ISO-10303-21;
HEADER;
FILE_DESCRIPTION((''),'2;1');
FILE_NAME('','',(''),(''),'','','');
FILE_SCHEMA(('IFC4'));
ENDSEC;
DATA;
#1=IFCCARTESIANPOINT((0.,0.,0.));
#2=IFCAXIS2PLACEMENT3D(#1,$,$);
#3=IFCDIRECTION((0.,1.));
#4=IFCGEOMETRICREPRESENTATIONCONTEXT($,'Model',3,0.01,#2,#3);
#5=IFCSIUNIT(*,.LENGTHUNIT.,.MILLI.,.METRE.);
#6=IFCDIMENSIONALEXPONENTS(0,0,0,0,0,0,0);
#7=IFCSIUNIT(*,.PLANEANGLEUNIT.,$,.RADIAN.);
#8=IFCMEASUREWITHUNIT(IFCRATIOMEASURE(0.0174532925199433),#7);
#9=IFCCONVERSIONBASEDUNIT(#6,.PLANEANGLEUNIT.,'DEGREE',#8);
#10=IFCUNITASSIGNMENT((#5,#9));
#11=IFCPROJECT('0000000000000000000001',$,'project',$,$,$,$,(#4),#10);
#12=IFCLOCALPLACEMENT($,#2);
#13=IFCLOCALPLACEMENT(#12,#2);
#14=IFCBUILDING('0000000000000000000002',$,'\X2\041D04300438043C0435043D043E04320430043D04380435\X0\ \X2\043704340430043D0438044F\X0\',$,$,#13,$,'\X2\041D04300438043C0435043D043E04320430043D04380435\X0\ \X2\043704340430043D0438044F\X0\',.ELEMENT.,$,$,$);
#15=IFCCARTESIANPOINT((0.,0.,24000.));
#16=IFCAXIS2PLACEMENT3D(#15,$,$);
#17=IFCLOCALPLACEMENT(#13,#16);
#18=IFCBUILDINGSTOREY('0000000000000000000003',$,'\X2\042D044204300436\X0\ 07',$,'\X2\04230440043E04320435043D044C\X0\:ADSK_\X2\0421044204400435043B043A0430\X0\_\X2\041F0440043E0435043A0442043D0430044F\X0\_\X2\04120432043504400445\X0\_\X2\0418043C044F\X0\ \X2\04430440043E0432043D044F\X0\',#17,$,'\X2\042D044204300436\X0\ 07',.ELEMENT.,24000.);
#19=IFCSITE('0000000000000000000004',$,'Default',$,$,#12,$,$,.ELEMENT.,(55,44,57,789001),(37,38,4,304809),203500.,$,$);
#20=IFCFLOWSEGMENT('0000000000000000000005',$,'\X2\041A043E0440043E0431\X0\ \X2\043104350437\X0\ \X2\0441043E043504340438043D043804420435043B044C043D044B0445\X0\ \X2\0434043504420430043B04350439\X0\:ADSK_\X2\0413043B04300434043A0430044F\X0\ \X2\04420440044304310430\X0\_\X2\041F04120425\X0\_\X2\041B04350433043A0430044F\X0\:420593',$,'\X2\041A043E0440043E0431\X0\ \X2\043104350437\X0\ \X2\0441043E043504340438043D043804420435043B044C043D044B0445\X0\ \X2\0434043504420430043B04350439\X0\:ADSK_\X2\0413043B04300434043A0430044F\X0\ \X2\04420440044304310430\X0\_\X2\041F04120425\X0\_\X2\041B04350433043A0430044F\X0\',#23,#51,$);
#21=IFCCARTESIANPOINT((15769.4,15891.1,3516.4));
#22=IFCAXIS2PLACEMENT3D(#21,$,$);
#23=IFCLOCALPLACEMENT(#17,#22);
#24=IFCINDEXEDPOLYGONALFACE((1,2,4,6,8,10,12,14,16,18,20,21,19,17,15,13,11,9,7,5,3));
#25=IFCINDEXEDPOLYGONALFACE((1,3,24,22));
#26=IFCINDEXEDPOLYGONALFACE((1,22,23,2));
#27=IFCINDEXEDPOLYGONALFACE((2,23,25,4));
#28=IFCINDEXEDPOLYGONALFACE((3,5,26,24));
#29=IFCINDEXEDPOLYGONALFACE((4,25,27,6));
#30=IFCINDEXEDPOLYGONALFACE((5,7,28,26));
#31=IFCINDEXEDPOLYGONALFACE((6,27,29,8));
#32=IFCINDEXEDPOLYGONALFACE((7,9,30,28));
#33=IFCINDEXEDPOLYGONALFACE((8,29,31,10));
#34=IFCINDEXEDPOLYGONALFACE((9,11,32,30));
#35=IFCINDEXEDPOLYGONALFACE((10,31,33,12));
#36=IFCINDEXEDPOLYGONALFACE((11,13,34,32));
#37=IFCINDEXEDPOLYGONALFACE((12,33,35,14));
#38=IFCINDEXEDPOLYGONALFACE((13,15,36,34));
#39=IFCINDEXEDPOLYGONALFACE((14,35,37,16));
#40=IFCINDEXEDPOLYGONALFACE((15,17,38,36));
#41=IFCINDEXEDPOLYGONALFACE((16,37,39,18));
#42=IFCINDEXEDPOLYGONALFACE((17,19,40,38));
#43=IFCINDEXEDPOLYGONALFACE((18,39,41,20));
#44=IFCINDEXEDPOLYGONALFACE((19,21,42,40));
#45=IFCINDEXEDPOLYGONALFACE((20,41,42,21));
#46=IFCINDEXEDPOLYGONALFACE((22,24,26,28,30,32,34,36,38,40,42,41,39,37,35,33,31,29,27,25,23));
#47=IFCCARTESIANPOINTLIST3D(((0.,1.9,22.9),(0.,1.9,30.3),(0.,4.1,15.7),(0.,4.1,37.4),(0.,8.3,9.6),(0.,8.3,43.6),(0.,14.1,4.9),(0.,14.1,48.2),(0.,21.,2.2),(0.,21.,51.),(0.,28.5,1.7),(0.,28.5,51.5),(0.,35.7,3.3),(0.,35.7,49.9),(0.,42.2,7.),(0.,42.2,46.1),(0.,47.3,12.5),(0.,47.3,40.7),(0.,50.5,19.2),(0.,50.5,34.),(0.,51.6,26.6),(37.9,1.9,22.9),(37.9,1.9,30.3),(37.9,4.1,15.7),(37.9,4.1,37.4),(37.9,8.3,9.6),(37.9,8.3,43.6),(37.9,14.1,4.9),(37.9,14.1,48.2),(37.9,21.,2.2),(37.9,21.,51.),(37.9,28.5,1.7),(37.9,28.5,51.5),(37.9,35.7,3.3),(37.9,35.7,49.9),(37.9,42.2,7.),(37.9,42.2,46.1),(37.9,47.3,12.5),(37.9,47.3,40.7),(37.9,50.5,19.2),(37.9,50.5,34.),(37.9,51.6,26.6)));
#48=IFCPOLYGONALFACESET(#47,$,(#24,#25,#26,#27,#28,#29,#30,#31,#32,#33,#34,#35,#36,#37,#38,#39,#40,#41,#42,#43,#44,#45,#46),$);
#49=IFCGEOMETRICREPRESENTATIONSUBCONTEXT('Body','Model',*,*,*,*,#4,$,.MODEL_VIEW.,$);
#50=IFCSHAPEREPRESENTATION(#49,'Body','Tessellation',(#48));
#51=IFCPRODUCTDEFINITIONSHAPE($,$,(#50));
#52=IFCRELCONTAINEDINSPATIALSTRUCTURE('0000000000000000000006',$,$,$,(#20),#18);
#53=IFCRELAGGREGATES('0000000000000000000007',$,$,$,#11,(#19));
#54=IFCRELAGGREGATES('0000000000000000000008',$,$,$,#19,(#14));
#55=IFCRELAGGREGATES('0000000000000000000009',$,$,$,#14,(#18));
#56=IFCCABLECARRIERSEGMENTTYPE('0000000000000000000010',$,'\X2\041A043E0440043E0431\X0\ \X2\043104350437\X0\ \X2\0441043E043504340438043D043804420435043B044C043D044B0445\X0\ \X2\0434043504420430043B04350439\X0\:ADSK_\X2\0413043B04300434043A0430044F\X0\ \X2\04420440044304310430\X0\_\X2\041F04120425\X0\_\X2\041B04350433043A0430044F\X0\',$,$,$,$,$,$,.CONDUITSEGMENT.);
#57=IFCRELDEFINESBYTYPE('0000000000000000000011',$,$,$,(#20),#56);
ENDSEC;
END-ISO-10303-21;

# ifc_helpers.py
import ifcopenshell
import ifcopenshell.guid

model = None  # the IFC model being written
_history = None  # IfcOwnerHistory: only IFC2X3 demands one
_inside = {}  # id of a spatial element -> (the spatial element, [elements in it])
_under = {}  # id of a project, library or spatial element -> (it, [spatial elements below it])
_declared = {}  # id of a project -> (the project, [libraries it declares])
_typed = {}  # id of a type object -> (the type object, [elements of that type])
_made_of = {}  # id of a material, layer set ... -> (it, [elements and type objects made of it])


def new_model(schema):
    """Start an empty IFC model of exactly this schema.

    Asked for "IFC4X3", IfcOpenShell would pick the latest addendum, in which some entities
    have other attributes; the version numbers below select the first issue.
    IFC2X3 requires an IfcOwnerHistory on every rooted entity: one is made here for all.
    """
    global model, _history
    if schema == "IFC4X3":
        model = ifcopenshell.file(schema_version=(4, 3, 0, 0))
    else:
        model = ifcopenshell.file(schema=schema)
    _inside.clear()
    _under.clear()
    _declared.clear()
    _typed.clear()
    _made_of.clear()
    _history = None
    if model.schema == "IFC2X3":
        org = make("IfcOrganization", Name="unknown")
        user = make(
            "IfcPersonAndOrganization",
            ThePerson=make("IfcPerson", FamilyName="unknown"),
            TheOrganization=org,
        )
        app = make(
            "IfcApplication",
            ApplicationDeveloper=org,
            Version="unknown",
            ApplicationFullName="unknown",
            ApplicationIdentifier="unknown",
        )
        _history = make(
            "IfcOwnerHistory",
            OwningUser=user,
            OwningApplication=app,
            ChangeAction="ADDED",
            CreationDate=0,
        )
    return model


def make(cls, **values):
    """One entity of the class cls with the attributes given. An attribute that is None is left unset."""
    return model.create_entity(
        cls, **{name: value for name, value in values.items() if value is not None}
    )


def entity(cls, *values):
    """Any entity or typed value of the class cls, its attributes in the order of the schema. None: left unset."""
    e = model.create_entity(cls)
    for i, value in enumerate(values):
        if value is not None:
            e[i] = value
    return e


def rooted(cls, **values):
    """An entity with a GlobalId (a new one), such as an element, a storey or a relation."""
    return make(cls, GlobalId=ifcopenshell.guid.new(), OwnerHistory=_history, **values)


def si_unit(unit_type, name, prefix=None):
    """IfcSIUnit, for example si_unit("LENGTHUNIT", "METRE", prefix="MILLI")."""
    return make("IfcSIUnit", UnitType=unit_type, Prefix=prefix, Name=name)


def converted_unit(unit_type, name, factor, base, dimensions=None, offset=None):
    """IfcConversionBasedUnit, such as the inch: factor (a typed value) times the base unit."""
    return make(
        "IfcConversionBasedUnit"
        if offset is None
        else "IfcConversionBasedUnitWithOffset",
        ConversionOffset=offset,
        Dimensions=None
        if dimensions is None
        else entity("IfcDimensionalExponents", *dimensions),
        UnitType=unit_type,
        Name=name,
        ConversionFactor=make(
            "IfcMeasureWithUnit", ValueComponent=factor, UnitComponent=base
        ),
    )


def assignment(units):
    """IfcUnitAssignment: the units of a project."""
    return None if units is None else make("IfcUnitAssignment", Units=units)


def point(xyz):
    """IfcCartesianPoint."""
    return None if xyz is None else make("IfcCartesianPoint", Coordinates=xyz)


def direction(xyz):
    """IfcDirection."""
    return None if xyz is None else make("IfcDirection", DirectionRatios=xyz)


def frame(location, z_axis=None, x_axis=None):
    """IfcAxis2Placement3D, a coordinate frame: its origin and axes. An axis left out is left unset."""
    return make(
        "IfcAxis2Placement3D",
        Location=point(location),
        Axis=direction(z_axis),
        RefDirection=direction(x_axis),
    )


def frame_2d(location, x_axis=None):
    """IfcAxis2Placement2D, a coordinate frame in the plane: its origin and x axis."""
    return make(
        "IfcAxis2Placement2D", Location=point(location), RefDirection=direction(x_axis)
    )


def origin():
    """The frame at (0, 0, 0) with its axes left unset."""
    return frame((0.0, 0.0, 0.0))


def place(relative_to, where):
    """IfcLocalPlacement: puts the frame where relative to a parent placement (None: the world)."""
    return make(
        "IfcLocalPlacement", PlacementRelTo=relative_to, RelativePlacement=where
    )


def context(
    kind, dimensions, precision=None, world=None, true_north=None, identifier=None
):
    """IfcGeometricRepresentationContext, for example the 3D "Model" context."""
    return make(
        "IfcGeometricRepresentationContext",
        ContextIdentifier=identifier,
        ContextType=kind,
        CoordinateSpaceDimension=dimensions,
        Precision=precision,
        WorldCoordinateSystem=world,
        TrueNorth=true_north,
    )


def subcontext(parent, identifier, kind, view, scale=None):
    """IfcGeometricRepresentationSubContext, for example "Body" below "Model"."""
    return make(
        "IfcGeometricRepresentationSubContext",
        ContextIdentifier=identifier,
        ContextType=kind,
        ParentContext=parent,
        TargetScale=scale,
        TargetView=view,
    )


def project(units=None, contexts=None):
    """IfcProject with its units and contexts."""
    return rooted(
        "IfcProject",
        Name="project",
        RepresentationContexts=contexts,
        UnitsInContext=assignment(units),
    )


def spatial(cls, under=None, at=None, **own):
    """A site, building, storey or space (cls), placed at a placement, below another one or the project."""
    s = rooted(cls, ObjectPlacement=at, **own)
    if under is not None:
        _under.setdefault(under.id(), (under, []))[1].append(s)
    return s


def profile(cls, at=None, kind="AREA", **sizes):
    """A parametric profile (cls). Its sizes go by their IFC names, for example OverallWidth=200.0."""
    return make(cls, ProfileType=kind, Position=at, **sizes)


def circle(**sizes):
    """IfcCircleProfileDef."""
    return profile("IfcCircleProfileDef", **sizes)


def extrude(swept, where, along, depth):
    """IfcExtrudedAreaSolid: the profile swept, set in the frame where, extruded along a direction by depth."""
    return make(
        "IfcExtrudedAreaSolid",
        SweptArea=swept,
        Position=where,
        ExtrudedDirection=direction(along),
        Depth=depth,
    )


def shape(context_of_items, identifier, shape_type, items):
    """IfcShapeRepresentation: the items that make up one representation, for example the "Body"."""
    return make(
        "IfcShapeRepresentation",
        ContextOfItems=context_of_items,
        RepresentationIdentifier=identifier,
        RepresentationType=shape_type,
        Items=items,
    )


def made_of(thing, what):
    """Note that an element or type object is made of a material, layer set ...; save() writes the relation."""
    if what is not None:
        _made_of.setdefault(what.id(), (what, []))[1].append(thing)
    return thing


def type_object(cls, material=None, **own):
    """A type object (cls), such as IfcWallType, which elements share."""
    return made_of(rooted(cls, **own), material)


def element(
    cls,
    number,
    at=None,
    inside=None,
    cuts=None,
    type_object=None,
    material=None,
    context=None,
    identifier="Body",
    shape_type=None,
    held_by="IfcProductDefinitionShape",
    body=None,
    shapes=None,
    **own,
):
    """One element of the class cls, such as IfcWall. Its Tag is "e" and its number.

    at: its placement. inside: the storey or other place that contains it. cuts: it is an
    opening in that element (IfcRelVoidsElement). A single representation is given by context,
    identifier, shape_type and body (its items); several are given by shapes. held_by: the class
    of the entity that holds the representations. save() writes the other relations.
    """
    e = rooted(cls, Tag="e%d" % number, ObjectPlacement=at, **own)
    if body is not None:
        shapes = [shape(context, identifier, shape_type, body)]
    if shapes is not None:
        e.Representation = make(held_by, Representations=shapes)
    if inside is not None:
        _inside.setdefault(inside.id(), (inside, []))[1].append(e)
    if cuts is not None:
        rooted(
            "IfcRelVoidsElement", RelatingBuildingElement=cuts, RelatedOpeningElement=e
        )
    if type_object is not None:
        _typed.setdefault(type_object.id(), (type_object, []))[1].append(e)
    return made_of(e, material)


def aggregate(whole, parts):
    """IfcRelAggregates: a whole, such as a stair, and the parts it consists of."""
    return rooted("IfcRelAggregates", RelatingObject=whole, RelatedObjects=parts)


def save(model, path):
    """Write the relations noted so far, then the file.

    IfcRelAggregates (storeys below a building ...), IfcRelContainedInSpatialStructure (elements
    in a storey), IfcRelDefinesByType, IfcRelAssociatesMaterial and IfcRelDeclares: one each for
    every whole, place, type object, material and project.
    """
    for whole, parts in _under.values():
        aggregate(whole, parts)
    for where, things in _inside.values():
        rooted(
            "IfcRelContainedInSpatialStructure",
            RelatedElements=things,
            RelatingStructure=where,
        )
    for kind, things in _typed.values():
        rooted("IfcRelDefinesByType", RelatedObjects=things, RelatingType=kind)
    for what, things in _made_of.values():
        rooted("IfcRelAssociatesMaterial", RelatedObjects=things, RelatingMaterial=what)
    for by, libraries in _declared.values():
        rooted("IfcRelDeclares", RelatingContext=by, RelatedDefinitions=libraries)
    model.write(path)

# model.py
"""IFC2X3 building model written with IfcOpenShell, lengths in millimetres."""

from ifc_helpers import new_model, entity, si_unit, converted_unit, direction, frame, frame_2d, origin, place, context, subcontext, project, spatial, circle, extrude, type_object, element, save


model = new_model("IFC2X3")

# Units and contexts
model_context = context("Model", 3, precision=0.01, world=origin(), true_north=direction((0.0, 1.0)))
body_context = subcontext(model_context, "Body", "Model", "MODEL_VIEW")
ifc_project = project(units=[si_unit("LENGTHUNIT", "METRE", prefix="MILLI"), converted_unit("PLANEANGLEUNIT", "DEGREE", entity("IfcRatioMeasure", 0.0174532925199433), si_unit("PLANEANGLEUNIT", "RADIAN"), dimensions=[0, 0, 0, 0, 0, 0, 0])], contexts=[model_context])

# Site, building, storey
site_placement = place(None, frame((0.0, 0.0, 0.0)))
site = spatial("IfcSite", under=ifc_project, at=site_placement, Name="Default", CompositionType="ELEMENT", RefLatitude=(55, 44, 57, 789001), RefLongitude=(37, 38, 4, 304809), RefElevation=203500.0)
building_placement = place(site_placement, origin())
building = spatial("IfcBuilding", under=site, at=building_placement, Name="Наименование здания", LongName="Наименование здания", CompositionType="ELEMENT")
storey_placement = place(building_placement, frame((0.0, 0.0, 24000.0)))
storey = spatial("IfcBuildingStorey", under=building, at=storey_placement, Name="Этаж 07", ObjectType="Уровень:ADSK_Стрелка_Проектная_Вверх_Имя уровня", LongName="Этаж 07", CompositionType="ELEMENT", Elevation=24000.0)

# Flow segment
cable_carrier_segment_type_1 = type_object("IfcCableCarrierSegmentType", Name="Короб без соединительных деталей:ADSK_Гладкая труба_ПВХ_Легкая", PredefinedType="CONDUITSEGMENT")
flow_segment_1_placement = place(storey_placement, frame((15769.4, 15891.1, 3516.4)))
element("IfcFlowSegment", 1, at=flow_segment_1_placement, inside=storey, type_object=cable_carrier_segment_type_1, Name="Короб без соединительных деталей:ADSK_Гладкая труба_ПВХ_Легкая:420593", ObjectType="Короб без соединительных деталей:ADSK_Гладкая труба_ПВХ_Легкая", context=body_context, shape_type="SweptSolid", body=[
    extrude(circle(Radius=25.0, at=frame_2d((0.0, 0.0), x_axis=(1.0, 0.0))), frame((0.0, 26.6, 26.6), z_axis=(1.0, 0.0, 0.0), x_axis=(0.0, 1.0, 0.0)), (0.0, 0.0, 1.0), 37.9),
])

save(model, "model.ifc")
